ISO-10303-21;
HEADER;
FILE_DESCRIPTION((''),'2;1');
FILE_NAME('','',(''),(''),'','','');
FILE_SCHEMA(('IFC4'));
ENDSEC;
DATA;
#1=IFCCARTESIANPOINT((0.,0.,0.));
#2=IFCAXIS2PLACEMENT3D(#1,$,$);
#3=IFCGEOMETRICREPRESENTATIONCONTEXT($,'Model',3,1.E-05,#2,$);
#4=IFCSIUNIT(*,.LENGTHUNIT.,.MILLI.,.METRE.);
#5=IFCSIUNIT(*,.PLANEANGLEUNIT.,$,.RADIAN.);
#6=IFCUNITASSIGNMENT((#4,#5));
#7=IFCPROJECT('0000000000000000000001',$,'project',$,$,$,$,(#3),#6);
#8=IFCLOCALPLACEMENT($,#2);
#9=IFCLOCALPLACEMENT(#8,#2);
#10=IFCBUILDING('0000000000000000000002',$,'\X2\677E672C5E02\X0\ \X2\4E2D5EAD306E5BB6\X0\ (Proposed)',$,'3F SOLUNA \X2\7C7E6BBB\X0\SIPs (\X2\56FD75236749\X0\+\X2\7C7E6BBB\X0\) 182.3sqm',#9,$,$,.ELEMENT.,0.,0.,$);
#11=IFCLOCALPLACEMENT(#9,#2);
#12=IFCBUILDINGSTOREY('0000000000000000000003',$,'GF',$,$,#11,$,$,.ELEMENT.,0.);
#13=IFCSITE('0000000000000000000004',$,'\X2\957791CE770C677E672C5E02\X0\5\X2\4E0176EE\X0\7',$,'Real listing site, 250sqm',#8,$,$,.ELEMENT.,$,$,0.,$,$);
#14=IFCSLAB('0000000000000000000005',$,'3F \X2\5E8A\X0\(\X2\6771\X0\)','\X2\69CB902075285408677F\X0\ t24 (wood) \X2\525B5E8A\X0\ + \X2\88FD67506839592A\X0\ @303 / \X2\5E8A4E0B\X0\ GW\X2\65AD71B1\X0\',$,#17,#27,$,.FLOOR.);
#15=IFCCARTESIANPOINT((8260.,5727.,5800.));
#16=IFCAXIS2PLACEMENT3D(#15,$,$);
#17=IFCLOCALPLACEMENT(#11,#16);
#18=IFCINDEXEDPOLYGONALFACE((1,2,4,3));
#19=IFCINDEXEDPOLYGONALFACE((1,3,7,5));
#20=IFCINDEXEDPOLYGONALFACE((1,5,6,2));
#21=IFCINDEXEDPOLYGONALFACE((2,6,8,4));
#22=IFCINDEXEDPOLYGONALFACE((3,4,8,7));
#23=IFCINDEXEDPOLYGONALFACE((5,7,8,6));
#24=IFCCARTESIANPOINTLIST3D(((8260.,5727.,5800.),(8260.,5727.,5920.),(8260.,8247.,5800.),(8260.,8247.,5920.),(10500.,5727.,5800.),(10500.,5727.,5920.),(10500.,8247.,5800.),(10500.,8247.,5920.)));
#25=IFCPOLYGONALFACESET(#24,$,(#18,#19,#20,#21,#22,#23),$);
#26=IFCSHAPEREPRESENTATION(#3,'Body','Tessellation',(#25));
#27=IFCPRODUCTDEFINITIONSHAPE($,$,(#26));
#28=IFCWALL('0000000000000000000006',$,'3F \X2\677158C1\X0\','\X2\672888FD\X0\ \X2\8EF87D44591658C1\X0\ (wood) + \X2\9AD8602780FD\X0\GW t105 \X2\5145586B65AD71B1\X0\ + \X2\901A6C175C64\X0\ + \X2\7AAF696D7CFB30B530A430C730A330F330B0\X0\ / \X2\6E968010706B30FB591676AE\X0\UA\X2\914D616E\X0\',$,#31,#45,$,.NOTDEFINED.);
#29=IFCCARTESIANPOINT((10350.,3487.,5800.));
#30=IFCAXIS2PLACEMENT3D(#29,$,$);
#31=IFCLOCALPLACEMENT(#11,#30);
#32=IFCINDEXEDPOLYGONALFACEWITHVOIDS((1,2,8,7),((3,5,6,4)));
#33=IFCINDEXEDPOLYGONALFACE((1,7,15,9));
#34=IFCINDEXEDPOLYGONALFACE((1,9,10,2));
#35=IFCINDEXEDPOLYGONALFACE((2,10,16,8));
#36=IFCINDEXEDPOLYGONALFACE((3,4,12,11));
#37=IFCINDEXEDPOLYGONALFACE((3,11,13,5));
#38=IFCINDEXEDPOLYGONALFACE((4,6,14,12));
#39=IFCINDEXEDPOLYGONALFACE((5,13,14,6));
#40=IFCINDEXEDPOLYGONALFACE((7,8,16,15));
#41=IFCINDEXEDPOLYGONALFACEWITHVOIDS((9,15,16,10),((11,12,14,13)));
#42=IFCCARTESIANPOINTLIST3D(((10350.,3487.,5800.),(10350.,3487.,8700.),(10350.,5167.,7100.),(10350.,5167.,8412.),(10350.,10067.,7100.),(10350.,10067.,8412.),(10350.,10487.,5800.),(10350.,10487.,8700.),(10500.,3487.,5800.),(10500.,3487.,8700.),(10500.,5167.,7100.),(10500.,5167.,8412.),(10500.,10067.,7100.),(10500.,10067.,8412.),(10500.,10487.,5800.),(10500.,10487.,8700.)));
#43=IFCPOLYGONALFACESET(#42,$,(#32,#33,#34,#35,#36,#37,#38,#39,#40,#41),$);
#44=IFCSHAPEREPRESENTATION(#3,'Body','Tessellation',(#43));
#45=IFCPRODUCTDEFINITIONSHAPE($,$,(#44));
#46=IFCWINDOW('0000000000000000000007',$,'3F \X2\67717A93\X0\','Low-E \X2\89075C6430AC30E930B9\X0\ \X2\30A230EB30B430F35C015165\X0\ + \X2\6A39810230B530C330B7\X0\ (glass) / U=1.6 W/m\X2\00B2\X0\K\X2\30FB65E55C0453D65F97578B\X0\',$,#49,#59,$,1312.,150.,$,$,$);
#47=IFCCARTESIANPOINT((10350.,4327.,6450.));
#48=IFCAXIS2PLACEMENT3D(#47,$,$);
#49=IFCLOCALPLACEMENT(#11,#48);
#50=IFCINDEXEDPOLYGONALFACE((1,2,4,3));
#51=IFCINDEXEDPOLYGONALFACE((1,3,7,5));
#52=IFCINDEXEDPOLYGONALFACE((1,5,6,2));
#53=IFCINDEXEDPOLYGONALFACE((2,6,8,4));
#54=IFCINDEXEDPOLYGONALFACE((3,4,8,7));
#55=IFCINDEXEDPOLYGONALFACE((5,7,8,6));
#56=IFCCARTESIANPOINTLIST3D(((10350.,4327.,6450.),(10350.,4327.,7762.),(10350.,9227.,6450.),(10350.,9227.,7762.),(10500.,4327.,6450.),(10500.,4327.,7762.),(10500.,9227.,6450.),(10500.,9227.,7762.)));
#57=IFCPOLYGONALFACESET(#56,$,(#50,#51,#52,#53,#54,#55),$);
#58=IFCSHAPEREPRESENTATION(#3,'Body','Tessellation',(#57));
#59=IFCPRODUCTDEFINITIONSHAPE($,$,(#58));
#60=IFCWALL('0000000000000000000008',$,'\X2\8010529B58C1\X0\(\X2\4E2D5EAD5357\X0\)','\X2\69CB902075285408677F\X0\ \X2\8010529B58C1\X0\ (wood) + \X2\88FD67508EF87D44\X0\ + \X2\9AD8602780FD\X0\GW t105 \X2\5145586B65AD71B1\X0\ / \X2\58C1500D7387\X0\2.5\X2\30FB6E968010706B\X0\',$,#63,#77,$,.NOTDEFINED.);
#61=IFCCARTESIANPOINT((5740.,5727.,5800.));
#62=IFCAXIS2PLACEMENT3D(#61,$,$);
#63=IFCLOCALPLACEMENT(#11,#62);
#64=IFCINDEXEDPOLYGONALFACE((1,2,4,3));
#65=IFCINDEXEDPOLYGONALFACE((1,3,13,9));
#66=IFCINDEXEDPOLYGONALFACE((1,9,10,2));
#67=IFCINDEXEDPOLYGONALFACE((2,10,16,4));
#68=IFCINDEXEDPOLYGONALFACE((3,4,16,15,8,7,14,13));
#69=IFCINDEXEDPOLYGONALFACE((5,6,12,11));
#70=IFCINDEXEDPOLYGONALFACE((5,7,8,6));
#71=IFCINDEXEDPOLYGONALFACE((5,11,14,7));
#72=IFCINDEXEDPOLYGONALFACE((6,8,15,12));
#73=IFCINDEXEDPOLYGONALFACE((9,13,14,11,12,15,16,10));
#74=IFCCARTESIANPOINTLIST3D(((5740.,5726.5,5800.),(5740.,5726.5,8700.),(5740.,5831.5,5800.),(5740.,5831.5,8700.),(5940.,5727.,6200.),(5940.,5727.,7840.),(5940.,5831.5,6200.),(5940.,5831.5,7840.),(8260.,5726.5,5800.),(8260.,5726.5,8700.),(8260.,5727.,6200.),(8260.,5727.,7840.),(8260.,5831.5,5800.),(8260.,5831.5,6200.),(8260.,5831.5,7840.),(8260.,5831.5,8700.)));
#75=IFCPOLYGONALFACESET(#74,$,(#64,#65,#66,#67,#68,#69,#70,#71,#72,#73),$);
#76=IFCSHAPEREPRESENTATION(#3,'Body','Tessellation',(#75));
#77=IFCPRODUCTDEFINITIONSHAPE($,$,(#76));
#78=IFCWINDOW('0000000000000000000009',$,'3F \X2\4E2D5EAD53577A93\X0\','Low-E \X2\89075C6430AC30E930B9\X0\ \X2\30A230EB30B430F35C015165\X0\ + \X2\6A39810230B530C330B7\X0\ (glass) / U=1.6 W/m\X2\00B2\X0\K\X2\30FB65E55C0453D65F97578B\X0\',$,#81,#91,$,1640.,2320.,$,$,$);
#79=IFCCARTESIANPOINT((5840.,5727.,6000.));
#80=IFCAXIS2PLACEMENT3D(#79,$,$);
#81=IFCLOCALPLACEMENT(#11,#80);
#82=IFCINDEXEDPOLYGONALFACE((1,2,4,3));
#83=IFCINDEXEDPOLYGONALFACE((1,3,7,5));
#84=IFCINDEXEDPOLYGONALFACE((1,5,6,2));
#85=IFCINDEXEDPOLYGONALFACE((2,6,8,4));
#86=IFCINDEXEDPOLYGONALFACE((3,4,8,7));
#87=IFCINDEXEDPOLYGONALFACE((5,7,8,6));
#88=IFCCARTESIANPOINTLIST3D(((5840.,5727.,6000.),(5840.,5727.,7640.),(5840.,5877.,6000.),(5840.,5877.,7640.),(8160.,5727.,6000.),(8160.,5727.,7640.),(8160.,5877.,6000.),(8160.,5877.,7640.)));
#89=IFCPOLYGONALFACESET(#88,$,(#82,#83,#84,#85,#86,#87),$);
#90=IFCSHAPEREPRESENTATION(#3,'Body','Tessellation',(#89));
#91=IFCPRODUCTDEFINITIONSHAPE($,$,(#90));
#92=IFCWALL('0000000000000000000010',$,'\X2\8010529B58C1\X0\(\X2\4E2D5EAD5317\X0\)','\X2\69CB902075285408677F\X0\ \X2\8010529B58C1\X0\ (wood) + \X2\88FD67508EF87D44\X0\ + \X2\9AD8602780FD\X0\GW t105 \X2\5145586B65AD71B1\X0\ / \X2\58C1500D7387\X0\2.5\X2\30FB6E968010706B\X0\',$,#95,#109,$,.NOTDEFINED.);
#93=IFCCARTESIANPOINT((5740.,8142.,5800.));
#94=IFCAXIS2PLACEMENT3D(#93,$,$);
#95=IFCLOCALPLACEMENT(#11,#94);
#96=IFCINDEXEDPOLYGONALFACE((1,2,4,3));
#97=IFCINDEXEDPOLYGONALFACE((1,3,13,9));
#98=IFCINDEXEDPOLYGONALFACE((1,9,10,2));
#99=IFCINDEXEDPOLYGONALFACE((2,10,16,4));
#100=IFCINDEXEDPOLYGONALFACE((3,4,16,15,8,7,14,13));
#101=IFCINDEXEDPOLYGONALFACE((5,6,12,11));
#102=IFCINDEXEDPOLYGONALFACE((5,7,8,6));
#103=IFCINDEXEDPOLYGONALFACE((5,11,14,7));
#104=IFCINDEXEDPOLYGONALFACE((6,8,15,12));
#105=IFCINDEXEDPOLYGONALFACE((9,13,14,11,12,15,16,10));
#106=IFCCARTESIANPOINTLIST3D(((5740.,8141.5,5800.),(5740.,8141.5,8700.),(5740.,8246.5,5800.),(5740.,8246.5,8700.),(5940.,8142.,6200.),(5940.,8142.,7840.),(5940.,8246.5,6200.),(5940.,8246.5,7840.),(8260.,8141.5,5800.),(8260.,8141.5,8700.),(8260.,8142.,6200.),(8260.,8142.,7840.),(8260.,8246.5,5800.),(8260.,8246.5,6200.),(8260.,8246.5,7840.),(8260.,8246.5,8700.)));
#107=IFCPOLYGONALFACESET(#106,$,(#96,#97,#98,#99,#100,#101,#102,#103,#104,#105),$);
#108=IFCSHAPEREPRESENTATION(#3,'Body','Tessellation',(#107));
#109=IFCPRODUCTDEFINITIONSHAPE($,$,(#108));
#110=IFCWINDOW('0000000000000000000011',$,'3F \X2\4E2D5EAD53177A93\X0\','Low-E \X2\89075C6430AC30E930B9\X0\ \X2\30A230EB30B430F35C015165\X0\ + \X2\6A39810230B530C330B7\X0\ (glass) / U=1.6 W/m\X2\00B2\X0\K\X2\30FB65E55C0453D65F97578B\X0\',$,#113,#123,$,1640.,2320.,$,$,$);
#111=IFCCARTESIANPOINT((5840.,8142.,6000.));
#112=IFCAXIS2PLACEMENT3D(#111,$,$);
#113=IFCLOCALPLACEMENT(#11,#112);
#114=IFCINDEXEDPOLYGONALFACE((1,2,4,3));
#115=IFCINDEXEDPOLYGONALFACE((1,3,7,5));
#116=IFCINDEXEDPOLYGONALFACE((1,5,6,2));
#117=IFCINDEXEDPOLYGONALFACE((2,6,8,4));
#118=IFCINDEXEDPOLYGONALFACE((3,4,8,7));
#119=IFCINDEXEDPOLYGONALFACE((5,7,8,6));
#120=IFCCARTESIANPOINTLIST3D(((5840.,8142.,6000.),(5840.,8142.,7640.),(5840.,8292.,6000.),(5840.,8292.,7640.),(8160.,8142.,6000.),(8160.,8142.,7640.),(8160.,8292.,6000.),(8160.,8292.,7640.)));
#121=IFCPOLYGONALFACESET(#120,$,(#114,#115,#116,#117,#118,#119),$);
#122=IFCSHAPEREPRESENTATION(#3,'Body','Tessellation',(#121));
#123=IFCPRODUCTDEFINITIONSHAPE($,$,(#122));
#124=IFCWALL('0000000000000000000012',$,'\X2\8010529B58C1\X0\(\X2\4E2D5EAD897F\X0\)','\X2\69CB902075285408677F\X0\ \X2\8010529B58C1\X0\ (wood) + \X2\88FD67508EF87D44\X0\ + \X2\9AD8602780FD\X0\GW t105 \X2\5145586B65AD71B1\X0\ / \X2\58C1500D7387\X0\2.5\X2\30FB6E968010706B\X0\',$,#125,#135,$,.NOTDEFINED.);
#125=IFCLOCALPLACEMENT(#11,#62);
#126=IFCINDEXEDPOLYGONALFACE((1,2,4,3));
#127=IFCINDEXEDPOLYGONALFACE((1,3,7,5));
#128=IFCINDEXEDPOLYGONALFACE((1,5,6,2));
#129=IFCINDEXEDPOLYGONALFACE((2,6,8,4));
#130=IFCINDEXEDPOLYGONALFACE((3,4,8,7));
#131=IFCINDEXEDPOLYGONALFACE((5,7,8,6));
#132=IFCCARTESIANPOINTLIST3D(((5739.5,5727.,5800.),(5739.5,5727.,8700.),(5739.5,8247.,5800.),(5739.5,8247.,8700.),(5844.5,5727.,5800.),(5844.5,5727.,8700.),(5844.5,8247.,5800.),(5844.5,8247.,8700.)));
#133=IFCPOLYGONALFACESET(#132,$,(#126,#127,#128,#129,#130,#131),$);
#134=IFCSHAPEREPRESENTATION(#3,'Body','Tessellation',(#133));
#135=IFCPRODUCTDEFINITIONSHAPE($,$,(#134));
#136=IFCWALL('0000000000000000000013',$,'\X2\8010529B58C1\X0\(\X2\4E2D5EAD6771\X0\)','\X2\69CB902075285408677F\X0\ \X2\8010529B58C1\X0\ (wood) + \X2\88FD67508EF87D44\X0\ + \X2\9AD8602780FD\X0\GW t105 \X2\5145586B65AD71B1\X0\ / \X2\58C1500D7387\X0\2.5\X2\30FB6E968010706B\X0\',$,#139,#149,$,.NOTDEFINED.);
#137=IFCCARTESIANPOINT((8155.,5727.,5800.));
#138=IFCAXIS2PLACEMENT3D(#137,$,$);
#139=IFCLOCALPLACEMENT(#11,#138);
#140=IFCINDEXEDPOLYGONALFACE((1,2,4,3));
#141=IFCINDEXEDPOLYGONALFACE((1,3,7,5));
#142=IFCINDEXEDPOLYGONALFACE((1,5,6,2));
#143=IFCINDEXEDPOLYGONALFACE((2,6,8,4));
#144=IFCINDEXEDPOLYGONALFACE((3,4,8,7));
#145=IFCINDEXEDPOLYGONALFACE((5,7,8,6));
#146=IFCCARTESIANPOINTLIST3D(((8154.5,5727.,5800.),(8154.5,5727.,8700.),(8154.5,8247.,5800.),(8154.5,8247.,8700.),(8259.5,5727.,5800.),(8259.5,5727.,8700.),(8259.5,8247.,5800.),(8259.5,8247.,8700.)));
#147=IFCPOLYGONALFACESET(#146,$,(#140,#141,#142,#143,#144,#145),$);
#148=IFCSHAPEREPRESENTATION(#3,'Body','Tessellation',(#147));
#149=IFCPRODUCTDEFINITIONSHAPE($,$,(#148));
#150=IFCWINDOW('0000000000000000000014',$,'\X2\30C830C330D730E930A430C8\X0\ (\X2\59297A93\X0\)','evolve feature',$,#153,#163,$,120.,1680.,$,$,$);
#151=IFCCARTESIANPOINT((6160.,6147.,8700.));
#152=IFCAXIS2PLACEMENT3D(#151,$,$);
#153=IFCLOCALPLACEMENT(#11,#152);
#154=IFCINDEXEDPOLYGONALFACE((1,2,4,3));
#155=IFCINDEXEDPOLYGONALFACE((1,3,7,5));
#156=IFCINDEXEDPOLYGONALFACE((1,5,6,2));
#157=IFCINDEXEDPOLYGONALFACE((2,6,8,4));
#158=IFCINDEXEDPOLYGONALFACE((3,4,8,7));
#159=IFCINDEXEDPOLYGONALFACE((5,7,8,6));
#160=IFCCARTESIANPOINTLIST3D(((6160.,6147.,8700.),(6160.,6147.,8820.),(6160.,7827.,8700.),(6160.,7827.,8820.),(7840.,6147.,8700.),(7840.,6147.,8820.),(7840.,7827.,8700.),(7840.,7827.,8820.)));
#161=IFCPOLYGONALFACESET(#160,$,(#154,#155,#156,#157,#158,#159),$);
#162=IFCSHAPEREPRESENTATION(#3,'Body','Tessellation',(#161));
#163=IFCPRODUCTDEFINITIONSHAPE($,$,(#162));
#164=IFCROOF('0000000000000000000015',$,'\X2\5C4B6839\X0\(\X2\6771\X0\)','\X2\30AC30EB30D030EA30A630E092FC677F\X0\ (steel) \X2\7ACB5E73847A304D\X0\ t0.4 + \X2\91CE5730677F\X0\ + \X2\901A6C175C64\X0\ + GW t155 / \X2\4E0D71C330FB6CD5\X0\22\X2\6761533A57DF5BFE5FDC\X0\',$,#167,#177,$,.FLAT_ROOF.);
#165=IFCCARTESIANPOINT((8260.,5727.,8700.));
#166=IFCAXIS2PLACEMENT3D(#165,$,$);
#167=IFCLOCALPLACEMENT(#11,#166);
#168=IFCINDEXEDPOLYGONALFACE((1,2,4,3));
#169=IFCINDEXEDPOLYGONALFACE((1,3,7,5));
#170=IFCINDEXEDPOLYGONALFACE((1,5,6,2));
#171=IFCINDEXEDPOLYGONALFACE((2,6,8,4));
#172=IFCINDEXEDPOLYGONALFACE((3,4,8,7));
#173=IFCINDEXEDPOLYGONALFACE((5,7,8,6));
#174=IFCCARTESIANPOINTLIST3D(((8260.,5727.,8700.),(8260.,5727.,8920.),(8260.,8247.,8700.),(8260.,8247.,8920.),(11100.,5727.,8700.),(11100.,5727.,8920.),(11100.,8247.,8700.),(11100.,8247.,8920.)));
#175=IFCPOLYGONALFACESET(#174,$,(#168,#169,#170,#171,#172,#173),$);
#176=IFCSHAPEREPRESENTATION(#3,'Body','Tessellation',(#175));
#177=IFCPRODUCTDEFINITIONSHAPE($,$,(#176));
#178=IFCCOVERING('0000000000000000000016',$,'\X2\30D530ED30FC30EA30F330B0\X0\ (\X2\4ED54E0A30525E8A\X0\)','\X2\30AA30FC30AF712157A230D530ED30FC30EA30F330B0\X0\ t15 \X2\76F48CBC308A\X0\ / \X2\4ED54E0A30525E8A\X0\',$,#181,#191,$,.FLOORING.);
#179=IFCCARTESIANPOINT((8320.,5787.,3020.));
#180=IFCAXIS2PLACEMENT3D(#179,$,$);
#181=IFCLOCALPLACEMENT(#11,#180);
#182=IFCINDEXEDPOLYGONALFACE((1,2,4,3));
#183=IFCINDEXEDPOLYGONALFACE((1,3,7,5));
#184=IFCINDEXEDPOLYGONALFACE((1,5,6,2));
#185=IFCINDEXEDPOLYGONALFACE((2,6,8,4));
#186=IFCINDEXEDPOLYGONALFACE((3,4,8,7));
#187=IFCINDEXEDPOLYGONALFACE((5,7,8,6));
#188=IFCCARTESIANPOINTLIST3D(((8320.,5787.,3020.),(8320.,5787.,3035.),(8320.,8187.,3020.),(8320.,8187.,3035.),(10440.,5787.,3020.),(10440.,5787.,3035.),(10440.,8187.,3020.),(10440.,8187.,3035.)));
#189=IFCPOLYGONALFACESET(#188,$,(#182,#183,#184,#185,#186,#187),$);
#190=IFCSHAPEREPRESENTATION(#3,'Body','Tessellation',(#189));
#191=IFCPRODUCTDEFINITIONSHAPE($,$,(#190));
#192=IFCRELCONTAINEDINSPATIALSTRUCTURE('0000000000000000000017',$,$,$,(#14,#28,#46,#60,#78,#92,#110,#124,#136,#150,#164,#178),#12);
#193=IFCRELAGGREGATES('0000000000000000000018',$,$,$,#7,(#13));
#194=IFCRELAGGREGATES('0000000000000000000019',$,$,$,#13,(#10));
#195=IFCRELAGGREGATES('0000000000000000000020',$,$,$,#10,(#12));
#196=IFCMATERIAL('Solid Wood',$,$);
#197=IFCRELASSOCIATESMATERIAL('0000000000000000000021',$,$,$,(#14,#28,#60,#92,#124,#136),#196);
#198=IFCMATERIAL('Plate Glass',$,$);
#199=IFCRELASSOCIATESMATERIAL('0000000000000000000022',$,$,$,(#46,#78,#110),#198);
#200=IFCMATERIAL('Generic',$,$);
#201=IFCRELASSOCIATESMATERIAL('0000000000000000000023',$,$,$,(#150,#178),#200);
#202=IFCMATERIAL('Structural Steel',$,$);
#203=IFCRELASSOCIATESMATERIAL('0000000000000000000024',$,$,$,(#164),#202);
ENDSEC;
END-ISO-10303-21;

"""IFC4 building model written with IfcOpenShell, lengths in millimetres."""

from ifc_helpers import new_model, si_unit, frame, frame_2d, origin, place, context, project, spatial, rectangle, extrude, material, element, fill, save


model = new_model("IFC4")

# Units and contexts
model_context = context("Model", 3, precision=1e-05, world=origin())
ifc_project = project(units=[si_unit("LENGTHUNIT", "METRE", prefix="MILLI"), si_unit("PLANEANGLEUNIT", "RADIAN")], contexts=[model_context])

# Site, building, storey
site_placement = place(None, origin())
site = spatial("IfcSite", under=ifc_project, at=site_placement, Name="長野県松本市5丁目7", ObjectType="Real listing site, 250sqm", CompositionType="ELEMENT", RefElevation=0.0)
building_placement = place(site_placement, origin())
building = spatial("IfcBuilding", under=site, at=building_placement, Name="松本市 中庭の家 (Proposed)", ObjectType="3F SOLUNA 籾殻SIPs (国産杉+籾殻) 182.3sqm", CompositionType="ELEMENT", ElevationOfRefHeight=0.0, ElevationOfTerrain=0.0)
storey_placement = place(building_placement, origin())
storey = spatial("IfcBuildingStorey", under=building, at=storey_placement, Name="GF", CompositionType="ELEMENT", Elevation=0.0)

# Slab
ifc_material_1 = material(Name="Solid Wood")
slab_placement = place(storey_placement, frame((8260.0, 5727.0, 5800.0)))
element("IfcSlab", 1, at=slab_placement, inside=storey, material=ifc_material_1, Name="3F 床(東)", Description="構造用合板 t24 (wood) 剛床 + 製材根太 @303 / 床下 GW断熱", PredefinedType="FLOOR", context=model_context, shape_type="SweptSolid", body=[
    extrude(rectangle(XDim=2240.0, YDim=2520.0, at=frame_2d((1120.0, 1260.0))), frame((8260.0, 5727.0, 5800.0)), (0.0, 0.0, 1.0), 120.0),
])

# Walls, openings, windows
wall_1_placement = place(storey_placement, frame((10350.0, 3487.0, 5800.0)))
wall_1 = element("IfcWall", 2, at=wall_1_placement, inside=storey, material=ifc_material_1, Name="3F 東壁", Description="木製 軸組外壁 (wood) + 高性能GW t105 充填断熱 + 通気層 + 窯業系サイディング / 準耐火・外皮UA配慮", PredefinedType="NOTDEFINED", context=model_context, shape_type="SweptSolid", body=[
    extrude(rectangle(XDim=150.0, YDim=7000.0, at=frame_2d((75.0, 3500.0))), frame((10350.0, 3487.0, 5800.0)), (0.0, 0.0, 1.0), 2900.0),
])
opening_1_placement = place(storey_placement, frame((10350.0, 4327.0, 6450.0)))
opening_1 = element("IfcOpeningElement", 3, at=opening_1_placement, cuts=wall_1, PredefinedType="NOTDEFINED", context=model_context, shape_type="SweptSolid", body=[
    extrude(rectangle(XDim=150.0, YDim=4900.0, at=frame_2d((75.0, 2450.0))), frame((10350.0, 4327.0, 6450.0)), (0.0, 0.0, 1.0), 1312.0),
])
ifc_material_2 = material(Name="Plate Glass")
window_1_placement = place(storey_placement, frame((10350.0, 4327.0, 6450.0)))
window_1 = element("IfcWindow", 4, at=window_1_placement, inside=storey, material=ifc_material_2, Name="3F 東窓", Description="Low-E 複層ガラス アルゴン封入 + 樹脂サッシ (glass) / U=1.6 W/m²K・日射取得型", OverallHeight=1312.0, OverallWidth=150.0, context=model_context, shape_type="SweptSolid", body=[
    extrude(rectangle(XDim=150.0, YDim=4900.0, at=frame_2d((75.0, 2450.0))), frame((10350.0, 4327.0, 6450.0)), (0.0, 0.0, 1.0), 1312.0),
])
fill(opening_1, window_1)
wall_2_placement = place(storey_placement, frame((5740.0, 5727.0, 5800.0)))
wall_2 = element("IfcWall", 5, at=wall_2_placement, inside=storey, material=ifc_material_1, Name="耐力壁(中庭南)", Description="構造用合板 耐力壁 (wood) + 製材軸組 + 高性能GW t105 充填断熱 / 壁倍率2.5・準耐火", PredefinedType="NOTDEFINED", context=model_context, shape_type="SweptSolid", body=[
    extrude(rectangle(XDim=2520.0, YDim=105.0, at=frame_2d((1260.0, 52.0))), frame((5740.0, 5727.0, 5800.0)), (0.0, 0.0, 1.0), 2900.0),
])
opening_2_placement = place(storey_placement, frame((5840.0, 5727.0, 6000.0)))
opening_2 = element("IfcOpeningElement", 6, at=opening_2_placement, cuts=wall_2, PredefinedType="NOTDEFINED", context=model_context, shape_type="SweptSolid", body=[
    extrude(rectangle(XDim=2320.0, YDim=150.0, at=frame_2d((1160.0, 75.0))), frame((5840.0, 5727.0, 6000.0)), (0.0, 0.0, 1.0), 1640.0),
])
window_2_placement = place(storey_placement, frame((5840.0, 5727.0, 6000.0)))
window_2 = element("IfcWindow", 7, at=window_2_placement, inside=storey, material=ifc_material_2, Name="3F 中庭南窓", Description="Low-E 複層ガラス アルゴン封入 + 樹脂サッシ (glass) / U=1.6 W/m²K・日射取得型", OverallHeight=1640.0, OverallWidth=2320.0, context=model_context, shape_type="SweptSolid", body=[
    extrude(rectangle(XDim=2320.0, YDim=150.0, at=frame_2d((1160.0, 75.0))), frame((5840.0, 5727.0, 6000.0)), (0.0, 0.0, 1.0), 1640.0),
])
fill(opening_2, window_2)
wall_3_placement = place(storey_placement, frame((5740.0, 8142.0, 5800.0)))
wall_3 = element("IfcWall", 8, at=wall_3_placement, inside=storey, material=ifc_material_1, Name="耐力壁(中庭北)", Description="構造用合板 耐力壁 (wood) + 製材軸組 + 高性能GW t105 充填断熱 / 壁倍率2.5・準耐火", PredefinedType="NOTDEFINED", context=model_context, shape_type="SweptSolid", body=[
    extrude(rectangle(XDim=2520.0, YDim=105.0, at=frame_2d((1260.0, 52.0))), frame((5740.0, 8142.0, 5800.0)), (0.0, 0.0, 1.0), 2900.0),
])
opening_3_placement = place(storey_placement, frame((5840.0, 8142.0, 6000.0)))
opening_3 = element("IfcOpeningElement", 9, at=opening_3_placement, cuts=wall_3, PredefinedType="NOTDEFINED", context=model_context, shape_type="SweptSolid", body=[
    extrude(rectangle(XDim=2320.0, YDim=150.0, at=frame_2d((1160.0, 75.0))), frame((5840.0, 8142.0, 6000.0)), (0.0, 0.0, 1.0), 1640.0),
])
window_3_placement = place(storey_placement, frame((5840.0, 8142.0, 6000.0)))
window_3 = element("IfcWindow", 10, at=window_3_placement, inside=storey, material=ifc_material_2, Name="3F 中庭北窓", Description="Low-E 複層ガラス アルゴン封入 + 樹脂サッシ (glass) / U=1.6 W/m²K・日射取得型", OverallHeight=1640.0, OverallWidth=2320.0, context=model_context, shape_type="SweptSolid", body=[
    extrude(rectangle(XDim=2320.0, YDim=150.0, at=frame_2d((1160.0, 75.0))), frame((5840.0, 8142.0, 6000.0)), (0.0, 0.0, 1.0), 1640.0),
])
fill(opening_3, window_3)

# Walls
wall_4_placement = place(storey_placement, frame((5740.0, 5727.0, 5800.0)))
element("IfcWall", 11, at=wall_4_placement, inside=storey, material=ifc_material_1, Name="耐力壁(中庭西)", Description="構造用合板 耐力壁 (wood) + 製材軸組 + 高性能GW t105 充填断熱 / 壁倍率2.5・準耐火", PredefinedType="NOTDEFINED", context=model_context, shape_type="SweptSolid", body=[
    extrude(rectangle(XDim=105.0, YDim=2520.0, at=frame_2d((52.0, 1260.0))), frame((5740.0, 5727.0, 5800.0)), (0.0, 0.0, 1.0), 2900.0),
])
wall_5_placement = place(storey_placement, frame((8155.0, 5727.0, 5800.0)))
element("IfcWall", 12, at=wall_5_placement, inside=storey, material=ifc_material_1, Name="耐力壁(中庭東)", Description="構造用合板 耐力壁 (wood) + 製材軸組 + 高性能GW t105 充填断熱 / 壁倍率2.5・準耐火", PredefinedType="NOTDEFINED", context=model_context, shape_type="SweptSolid", body=[
    extrude(rectangle(XDim=105.0, YDim=2520.0, at=frame_2d((52.0, 1260.0))), frame((8155.0, 5727.0, 5800.0)), (0.0, 0.0, 1.0), 2900.0),
])

# Window
ifc_material_3 = material(Name="Generic")
window_4_placement = place(storey_placement, frame((6160.0, 6147.0, 8700.0)))
element("IfcWindow", 13, at=window_4_placement, inside=storey, material=ifc_material_3, Name="トップライト (天窓)", Description="evolve feature", OverallHeight=120.0, OverallWidth=1680.0, context=model_context, shape_type="SweptSolid", body=[
    extrude(rectangle(XDim=1680.0, YDim=1680.0, at=frame_2d((840.0, 840.0))), frame((6160.0, 6147.0, 8700.0)), (0.0, 0.0, 1.0), 120.0),
])

# Roof
ifc_material_4 = material(Name="Structural Steel")
for number, where, name in (
    (14, (8260.0, 5727.0, 8700.0), "屋根(東)"),
):
    element("IfcRoof", number, at=place(storey_placement, frame(where)), inside=storey, material=ifc_material_4, Name=name, Description="ガルバリウム鋼板 (steel) 立平葺き t0.4 + 野地板 + 通気層 + GW t155 / 不燃・法22条区域対応", PredefinedType="FLAT_ROOF", context=model_context, shape_type="SweptSolid", body=[
        extrude(rectangle(XDim=2840.0, YDim=2520.0, at=frame_2d((1420.0, 1260.0))), frame((8260.0, 5727.0, 8700.0)), (0.0, 0.0, 1.0), 220.0),
    ])

# Covering
covering_1_placement = place(storey_placement, frame((8320.0, 5787.0, 3020.0)))
element("IfcCovering", 15, at=covering_1_placement, inside=storey, material=ifc_material_3, Name="フローリング (仕上げ床)", Description="オーク無垢フローリング t15 直貼り / 仕上げ床", PredefinedType="FLOORING", context=model_context, shape_type="SweptSolid", body=[
    extrude(rectangle(XDim=2120.0, YDim=2400.0, at=frame_2d((1060.0, 1200.0))), frame((8320.0, 5787.0, 3020.0)), (0.0, 0.0, 1.0), 15.0),
])

save(model, "model.ifc")
